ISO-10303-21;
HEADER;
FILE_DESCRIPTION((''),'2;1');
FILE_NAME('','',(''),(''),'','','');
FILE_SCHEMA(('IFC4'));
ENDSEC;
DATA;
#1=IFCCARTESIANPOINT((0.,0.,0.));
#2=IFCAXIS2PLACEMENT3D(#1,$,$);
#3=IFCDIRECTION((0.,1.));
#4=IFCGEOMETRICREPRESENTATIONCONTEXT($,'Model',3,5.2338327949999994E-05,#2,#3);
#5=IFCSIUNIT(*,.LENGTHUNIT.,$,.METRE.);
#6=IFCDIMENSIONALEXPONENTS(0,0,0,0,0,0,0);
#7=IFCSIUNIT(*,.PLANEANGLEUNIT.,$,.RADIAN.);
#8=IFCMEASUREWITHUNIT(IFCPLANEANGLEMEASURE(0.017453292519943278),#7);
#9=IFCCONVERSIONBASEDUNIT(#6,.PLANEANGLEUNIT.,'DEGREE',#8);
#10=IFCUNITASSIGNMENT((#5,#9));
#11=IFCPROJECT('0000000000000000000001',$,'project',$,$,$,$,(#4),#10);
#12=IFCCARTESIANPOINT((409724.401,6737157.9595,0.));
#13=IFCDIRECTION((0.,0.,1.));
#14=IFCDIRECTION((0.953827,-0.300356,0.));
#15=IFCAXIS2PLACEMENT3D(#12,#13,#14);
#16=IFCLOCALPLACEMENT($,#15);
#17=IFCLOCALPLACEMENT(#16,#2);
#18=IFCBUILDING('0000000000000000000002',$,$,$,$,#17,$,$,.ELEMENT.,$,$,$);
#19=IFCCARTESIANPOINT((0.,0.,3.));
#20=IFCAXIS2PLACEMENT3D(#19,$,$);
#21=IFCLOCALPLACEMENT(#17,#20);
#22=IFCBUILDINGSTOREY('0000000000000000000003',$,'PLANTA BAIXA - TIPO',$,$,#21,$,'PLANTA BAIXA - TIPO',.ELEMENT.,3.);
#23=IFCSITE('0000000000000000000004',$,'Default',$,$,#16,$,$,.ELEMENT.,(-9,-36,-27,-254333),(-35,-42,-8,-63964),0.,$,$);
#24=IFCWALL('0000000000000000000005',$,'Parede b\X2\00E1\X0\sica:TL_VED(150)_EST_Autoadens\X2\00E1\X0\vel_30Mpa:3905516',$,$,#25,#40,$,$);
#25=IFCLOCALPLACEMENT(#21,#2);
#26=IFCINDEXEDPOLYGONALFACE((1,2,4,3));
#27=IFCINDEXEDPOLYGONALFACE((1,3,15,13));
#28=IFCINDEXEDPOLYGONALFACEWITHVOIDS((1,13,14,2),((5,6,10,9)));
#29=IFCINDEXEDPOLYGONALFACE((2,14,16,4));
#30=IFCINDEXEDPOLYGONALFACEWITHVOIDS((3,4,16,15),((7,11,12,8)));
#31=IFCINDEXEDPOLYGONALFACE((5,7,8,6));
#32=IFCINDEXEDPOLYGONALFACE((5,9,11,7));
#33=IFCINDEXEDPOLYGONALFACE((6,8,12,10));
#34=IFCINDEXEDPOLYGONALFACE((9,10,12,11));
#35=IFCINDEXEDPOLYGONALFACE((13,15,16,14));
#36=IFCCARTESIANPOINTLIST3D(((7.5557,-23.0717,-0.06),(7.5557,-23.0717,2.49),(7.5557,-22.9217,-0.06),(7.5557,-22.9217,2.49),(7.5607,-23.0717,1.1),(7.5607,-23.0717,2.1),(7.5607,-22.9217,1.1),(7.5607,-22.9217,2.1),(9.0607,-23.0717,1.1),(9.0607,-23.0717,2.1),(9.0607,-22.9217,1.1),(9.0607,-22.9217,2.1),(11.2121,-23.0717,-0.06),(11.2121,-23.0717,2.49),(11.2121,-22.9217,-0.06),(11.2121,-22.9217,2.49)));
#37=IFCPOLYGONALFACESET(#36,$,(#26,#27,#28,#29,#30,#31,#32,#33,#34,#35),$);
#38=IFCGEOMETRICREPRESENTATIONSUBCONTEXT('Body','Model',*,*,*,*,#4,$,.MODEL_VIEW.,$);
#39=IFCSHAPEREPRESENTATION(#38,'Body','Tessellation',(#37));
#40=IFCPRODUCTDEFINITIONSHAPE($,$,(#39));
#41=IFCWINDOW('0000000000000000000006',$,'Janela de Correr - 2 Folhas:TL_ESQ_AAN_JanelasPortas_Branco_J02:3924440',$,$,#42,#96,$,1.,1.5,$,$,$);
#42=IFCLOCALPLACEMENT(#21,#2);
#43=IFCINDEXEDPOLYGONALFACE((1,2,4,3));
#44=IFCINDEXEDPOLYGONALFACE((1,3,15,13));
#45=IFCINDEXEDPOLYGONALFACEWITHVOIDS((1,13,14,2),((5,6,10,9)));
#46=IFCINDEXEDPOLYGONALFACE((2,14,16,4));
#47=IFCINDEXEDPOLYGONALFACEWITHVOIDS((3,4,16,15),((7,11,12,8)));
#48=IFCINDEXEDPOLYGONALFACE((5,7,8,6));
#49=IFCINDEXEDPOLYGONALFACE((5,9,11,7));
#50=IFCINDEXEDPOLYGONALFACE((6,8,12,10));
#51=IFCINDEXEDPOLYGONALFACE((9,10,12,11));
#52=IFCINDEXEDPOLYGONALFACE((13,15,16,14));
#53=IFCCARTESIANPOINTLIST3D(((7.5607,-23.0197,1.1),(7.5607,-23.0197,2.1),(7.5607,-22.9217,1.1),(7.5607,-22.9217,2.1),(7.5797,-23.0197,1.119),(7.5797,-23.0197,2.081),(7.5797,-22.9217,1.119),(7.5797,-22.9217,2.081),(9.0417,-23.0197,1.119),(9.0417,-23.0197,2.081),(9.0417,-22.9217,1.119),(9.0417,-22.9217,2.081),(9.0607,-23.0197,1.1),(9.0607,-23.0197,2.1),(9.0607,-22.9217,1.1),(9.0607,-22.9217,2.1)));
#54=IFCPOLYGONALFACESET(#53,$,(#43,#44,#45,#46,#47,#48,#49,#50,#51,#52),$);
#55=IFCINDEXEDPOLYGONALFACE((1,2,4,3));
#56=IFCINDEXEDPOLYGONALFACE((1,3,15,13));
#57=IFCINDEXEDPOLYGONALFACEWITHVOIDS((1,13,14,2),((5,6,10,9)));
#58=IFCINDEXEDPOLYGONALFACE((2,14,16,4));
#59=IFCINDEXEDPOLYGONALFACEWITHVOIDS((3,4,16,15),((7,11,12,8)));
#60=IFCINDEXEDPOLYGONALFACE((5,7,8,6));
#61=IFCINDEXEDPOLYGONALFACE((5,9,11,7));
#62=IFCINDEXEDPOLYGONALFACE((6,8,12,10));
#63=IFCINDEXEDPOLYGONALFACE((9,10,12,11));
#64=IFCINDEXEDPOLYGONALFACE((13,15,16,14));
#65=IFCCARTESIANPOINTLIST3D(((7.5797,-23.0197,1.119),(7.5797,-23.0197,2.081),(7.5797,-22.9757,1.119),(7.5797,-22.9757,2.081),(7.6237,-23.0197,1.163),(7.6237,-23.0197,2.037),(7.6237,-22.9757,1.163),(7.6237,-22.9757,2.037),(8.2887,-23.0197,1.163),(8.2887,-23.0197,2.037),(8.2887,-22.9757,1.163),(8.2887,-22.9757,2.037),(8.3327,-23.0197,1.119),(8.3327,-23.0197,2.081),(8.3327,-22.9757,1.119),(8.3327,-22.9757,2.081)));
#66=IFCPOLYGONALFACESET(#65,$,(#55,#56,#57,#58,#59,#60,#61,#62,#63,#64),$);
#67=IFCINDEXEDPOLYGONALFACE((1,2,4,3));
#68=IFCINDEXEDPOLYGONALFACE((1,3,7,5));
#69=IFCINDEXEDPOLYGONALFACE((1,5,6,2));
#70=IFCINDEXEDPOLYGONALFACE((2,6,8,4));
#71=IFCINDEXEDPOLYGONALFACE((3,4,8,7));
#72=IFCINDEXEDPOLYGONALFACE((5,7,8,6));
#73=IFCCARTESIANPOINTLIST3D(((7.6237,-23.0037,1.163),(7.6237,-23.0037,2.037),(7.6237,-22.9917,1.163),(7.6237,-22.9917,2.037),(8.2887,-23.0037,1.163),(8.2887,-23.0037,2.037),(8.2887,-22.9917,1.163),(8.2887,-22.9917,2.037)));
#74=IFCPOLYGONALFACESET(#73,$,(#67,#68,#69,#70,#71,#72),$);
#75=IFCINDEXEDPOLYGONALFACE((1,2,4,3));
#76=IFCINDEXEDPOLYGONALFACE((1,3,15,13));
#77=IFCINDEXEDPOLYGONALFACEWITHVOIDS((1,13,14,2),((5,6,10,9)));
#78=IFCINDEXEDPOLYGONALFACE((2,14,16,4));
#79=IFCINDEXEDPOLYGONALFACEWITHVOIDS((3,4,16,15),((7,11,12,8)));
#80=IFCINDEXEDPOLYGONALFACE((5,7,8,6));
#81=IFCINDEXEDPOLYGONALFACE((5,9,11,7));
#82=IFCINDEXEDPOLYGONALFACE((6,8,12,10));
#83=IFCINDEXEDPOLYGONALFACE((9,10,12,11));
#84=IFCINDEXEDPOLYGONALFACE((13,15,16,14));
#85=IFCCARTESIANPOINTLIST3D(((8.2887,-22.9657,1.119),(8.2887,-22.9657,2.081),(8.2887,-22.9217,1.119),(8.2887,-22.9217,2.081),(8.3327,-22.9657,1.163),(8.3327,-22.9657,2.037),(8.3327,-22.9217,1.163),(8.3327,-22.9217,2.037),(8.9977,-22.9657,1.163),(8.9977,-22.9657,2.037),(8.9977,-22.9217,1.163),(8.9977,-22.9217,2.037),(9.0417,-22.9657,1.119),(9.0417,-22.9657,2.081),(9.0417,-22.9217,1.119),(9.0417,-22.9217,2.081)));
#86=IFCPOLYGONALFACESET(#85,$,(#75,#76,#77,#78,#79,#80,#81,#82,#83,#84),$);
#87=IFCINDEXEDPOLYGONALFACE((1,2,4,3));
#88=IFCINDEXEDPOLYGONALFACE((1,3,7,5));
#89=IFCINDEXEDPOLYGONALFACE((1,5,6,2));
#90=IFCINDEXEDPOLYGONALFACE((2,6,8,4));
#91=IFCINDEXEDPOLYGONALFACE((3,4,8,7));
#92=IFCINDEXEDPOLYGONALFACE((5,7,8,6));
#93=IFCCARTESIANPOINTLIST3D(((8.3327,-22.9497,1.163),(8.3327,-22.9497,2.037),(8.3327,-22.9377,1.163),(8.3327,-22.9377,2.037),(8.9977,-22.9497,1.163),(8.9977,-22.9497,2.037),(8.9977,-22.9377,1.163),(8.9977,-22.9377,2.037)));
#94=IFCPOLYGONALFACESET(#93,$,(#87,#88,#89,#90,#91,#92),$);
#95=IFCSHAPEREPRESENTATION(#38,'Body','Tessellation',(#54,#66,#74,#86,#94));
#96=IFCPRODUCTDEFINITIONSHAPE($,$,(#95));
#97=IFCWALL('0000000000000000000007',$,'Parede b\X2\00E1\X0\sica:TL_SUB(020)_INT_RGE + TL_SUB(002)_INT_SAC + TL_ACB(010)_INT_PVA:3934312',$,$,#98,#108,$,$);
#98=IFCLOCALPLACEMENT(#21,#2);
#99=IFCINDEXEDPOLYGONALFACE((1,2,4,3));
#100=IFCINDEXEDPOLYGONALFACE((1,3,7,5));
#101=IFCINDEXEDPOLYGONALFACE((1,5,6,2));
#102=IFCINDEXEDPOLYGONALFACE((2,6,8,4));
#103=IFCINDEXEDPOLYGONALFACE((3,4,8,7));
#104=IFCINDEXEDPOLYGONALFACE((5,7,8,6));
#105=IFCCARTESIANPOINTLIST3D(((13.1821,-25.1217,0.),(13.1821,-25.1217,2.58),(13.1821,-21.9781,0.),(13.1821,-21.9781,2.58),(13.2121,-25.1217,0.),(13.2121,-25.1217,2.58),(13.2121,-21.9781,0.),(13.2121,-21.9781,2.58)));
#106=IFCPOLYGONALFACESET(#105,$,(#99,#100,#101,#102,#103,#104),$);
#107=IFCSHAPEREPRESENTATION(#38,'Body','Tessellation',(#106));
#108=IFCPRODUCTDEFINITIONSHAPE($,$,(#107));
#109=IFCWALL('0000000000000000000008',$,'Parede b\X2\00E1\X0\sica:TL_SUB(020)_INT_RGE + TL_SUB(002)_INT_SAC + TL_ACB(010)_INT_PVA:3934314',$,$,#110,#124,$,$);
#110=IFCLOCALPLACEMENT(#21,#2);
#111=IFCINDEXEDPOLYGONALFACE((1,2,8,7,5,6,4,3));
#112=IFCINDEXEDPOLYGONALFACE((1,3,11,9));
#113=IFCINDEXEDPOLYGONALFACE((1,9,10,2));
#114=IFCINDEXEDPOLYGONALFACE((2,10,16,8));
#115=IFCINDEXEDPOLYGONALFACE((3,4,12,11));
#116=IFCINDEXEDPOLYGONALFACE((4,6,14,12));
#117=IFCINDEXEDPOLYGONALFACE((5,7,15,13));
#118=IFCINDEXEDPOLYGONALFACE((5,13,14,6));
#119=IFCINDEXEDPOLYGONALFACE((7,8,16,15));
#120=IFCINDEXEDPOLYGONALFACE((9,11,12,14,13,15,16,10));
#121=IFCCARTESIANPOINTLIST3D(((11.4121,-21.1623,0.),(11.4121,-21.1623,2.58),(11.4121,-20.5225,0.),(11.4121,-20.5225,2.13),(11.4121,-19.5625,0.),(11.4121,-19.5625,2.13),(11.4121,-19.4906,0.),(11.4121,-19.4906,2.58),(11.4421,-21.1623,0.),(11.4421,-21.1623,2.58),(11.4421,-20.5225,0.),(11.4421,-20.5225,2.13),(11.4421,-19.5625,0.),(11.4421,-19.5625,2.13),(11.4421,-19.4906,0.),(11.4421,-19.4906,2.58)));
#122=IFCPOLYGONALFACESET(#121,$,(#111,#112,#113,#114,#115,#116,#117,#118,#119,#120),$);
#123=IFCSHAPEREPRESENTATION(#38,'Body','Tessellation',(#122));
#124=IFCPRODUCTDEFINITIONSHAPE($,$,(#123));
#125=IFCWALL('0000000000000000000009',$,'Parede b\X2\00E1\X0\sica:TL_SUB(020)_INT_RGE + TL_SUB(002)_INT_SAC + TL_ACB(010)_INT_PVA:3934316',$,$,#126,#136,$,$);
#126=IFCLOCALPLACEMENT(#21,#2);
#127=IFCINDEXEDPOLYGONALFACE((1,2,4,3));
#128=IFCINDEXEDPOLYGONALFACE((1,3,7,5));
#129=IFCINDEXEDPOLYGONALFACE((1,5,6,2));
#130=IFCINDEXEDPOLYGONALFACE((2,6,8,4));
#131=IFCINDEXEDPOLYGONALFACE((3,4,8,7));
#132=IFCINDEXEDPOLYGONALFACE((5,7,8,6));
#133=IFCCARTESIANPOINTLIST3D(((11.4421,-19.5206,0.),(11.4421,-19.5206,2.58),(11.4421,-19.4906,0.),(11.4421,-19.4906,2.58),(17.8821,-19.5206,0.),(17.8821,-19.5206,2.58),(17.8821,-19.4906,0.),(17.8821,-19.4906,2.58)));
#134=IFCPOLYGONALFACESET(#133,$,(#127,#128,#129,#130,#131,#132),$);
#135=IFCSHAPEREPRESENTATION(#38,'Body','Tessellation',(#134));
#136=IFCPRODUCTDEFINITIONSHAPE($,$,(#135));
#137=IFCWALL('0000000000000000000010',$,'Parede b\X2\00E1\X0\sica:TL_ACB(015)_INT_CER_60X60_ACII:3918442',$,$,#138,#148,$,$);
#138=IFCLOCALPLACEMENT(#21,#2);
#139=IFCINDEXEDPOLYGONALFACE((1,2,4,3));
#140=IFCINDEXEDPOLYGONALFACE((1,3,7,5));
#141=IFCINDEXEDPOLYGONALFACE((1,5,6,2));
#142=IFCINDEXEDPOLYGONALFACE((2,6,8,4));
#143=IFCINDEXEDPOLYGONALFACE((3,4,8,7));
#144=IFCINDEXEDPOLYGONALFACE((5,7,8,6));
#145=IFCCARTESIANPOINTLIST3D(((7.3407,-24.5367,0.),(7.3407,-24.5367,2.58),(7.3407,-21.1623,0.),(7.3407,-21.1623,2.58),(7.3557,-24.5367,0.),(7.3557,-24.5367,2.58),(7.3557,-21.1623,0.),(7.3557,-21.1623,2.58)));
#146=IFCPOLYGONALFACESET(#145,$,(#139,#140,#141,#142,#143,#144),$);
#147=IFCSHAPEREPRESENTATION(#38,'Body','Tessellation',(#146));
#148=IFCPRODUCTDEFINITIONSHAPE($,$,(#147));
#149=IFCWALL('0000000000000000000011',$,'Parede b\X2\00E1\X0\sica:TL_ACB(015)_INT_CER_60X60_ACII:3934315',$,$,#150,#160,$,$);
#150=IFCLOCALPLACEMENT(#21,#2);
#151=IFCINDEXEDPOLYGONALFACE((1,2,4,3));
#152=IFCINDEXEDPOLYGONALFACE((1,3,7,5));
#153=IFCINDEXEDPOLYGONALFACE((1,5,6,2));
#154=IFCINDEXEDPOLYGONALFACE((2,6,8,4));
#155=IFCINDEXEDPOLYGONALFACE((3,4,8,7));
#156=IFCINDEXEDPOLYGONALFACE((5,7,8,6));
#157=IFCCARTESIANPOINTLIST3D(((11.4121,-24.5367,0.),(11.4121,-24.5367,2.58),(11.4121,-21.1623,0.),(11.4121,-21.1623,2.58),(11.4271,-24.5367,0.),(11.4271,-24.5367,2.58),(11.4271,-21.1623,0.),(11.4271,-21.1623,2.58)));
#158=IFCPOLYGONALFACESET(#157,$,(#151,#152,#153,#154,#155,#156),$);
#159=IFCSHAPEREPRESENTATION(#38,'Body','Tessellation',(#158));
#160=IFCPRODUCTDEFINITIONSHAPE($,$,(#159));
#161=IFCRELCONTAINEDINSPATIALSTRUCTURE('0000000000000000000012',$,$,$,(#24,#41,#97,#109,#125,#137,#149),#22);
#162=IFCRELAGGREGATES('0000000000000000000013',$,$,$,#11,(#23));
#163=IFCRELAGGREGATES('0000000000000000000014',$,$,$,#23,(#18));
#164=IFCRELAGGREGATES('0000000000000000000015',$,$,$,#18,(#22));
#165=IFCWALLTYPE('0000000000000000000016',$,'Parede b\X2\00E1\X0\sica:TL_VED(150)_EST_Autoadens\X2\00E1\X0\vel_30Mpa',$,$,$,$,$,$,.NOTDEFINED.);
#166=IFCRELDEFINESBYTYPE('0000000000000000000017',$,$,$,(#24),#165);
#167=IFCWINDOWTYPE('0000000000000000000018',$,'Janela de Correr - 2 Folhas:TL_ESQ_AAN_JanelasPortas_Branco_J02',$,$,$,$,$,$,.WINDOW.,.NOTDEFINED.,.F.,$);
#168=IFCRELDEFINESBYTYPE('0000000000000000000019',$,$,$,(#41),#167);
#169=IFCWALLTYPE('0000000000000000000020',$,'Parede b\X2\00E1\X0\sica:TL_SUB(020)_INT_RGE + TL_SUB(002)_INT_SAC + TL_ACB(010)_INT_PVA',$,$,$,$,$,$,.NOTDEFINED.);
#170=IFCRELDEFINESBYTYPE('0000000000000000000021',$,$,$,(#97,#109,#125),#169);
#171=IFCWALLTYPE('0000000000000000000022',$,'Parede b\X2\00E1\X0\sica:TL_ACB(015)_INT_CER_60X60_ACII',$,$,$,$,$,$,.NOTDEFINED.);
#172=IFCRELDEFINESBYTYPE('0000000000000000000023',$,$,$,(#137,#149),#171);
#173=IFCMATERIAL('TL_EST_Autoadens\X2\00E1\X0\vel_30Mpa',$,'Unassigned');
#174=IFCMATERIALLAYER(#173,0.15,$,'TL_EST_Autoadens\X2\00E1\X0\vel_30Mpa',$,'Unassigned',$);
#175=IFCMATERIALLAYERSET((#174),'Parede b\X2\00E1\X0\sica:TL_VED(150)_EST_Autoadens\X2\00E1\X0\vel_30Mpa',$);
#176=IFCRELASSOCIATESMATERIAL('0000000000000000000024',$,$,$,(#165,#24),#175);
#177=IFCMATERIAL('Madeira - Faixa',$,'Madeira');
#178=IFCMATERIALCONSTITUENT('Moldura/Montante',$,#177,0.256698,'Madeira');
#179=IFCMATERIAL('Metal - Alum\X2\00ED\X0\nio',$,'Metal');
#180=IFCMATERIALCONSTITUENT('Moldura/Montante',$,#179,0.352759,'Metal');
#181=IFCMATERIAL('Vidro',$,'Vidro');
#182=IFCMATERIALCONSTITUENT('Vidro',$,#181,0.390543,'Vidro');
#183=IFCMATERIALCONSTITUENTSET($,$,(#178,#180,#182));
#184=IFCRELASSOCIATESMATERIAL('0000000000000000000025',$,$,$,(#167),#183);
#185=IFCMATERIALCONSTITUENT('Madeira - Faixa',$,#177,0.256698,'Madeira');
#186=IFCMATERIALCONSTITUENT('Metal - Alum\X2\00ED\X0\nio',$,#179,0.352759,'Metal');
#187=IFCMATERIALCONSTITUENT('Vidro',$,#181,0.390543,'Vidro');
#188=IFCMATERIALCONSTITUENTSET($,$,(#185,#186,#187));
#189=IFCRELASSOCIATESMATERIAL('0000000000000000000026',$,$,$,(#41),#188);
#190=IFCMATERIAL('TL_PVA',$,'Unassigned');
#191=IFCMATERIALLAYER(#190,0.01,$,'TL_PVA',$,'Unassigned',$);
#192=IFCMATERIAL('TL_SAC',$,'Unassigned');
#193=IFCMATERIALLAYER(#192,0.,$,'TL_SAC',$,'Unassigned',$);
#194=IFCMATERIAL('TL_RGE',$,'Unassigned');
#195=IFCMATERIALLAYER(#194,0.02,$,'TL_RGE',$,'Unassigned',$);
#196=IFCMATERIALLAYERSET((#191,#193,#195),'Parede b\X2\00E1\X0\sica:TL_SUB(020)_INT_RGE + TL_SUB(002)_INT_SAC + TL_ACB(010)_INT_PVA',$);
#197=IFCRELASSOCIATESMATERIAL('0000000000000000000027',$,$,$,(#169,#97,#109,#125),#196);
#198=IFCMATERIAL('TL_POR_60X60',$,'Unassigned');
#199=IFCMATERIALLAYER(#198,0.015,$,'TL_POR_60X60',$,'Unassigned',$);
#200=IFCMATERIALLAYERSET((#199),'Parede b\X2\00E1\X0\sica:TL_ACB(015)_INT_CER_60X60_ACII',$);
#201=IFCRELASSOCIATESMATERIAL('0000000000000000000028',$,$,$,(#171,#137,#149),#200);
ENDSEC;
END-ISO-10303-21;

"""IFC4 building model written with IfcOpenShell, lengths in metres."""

from ifc_helpers import new_model, entity, si_unit, converted_unit, direction, frame, frame_2d, origin, origin_2d_with_axis, place, context, subcontext, project, spatial, polyline, rectangle, outline, extrude, source, transform, mapped, material, layer, layer_set, layer_usage, constituent, constituent_set, type_object, type_shapes, element, fill, save


model = new_model("IFC4")

# Units and contexts
model_context = context("Model", 3, precision=5.2338327949999994e-05, world=origin(), true_north=direction((0.0, 1.0)))
body_context = subcontext(model_context, "Body", "Model", "MODEL_VIEW")
ifc_project = project(units=[si_unit("LENGTHUNIT", "METRE"), converted_unit("PLANEANGLEUNIT", "DEGREE", entity("IfcPlaneAngleMeasure", 0.017453292519943278), si_unit("PLANEANGLEUNIT", "RADIAN"), dimensions=[0, 0, 0, 0, 0, 0, 0])], contexts=[model_context])

# Site, building, storey
site_placement = place(None, frame((409724.401, 6737157.9595, 0.0), z_axis=(0.0, 0.0, 1.0), x_axis=(0.953827, -0.300356, 0.0)))
site = spatial("IfcSite", under=ifc_project, at=site_placement, Name="Default", CompositionType="ELEMENT", RefLatitude=(-9, -36, -27, -254333), RefLongitude=(-35, -42, -8, -63964), RefElevation=0.0)
building_placement = place(site_placement, origin())
building = spatial("IfcBuilding", under=site, at=building_placement, CompositionType="ELEMENT")
storey_placement = place(building_placement, frame((0.0, 0.0, 3.0)))
storey = spatial("IfcBuildingStorey", under=building, at=storey_placement, Name="PLANTA BAIXA - TIPO", LongName="PLANTA BAIXA - TIPO", CompositionType="ELEMENT", Elevation=3.0)

# Shared definitions
ifc_material_1 = material(Name="TL_POR_60X60", Category="Unassigned")

# Wall, opening, window
ifc_material_2 = material(Name="TL_EST_Autoadensável_30Mpa", Category="Unassigned")
ifc_material_3 = material(Name="Madeira - Faixa", Category="Madeira")
ifc_material_4 = material(Name="Metal - Alumínio", Category="Metal")
ifc_material_5 = material(Name="Vidro", Category="Vidro")
ifc_layer_1 = layer(ifc_material_2, 0.15, Name="TL_EST_Autoadensável_30Mpa", Category="Unassigned")
ifc_layer_set_1 = layer_set([ifc_layer_1], Name="Parede básica:TL_VED(150)_EST_Autoadensável_30Mpa")
ifc_layer_usage_1 = layer_usage(ifc_layer_set_1, "AXIS2", "POSITIVE", -0.075)
wall_type_1 = type_object("IfcWallType", Name="Parede básica:TL_VED(150)_EST_Autoadensável_30Mpa", PredefinedType="NOTDEFINED", material=ifc_layer_set_1)
wall_1_placement = place(storey_placement, frame((7.5557, -22.9967, -0.06)))
wall_1 = element("IfcWall", 1, at=wall_1_placement, inside=storey, type_object=wall_type_1, material=ifc_layer_usage_1, Name="Parede básica:TL_VED(150)_EST_Autoadensável_30Mpa:3905516", context=body_context, shape_type="SweptSolid", body=[
    extrude(rectangle(XDim=3.6564, YDim=0.15, at=frame_2d((1.8282, 0.0), x_axis=(-1.0, 0.0))), origin(), (0.0, 0.0, 1.0), 2.55),
])
opening_1_placement = place(wall_1_placement, frame((1.505, 0.075, 1.16)))
opening_1 = element("IfcOpeningElement", 2, at=opening_1_placement, cuts=wall_1, PredefinedType="OPENING", context=body_context, shape_type="SweptSolid", body=[
    extrude(rectangle(XDim=1.0, YDim=1.5, at=frame_2d((0.5, 0.75), x_axis=(-1.0, 0.0))), frame((0.0, 0.0, 0.0), z_axis=(0.0, -1.0, 0.0), x_axis=(0.0, 0.0, 1.0)), (0.0, 0.0, 1.0), 0.15),
])
ifc_constituent_1 = constituent(ifc_material_3, Name="Madeira - Faixa", Category="Madeira", fraction=0.256698)
ifc_constituent_2 = constituent(ifc_material_4, Name="Metal - Alumínio", Category="Metal", fraction=0.352759)
ifc_constituent_3 = constituent(ifc_material_5, Name="Vidro", Category="Vidro", fraction=0.390543)
ifc_constituent_set_1 = constituent_set(constituents=[ifc_constituent_1, ifc_constituent_2, ifc_constituent_3])
ifc_constituent_4 = constituent(ifc_material_3, Name="Moldura/Montante", Category="Madeira", fraction=0.256698)
ifc_constituent_5 = constituent(ifc_material_4, Name="Moldura/Montante", Category="Metal", fraction=0.352759)
ifc_constituent_6 = constituent(ifc_material_5, Name="Vidro", Category="Vidro", fraction=0.390543)
ifc_constituent_set_2 = constituent_set(constituents=[ifc_constituent_4, ifc_constituent_5, ifc_constituent_6])
window_type_1 = type_object("IfcWindowType", Name="Janela de Correr - 2 Folhas:TL_ESQ_AAN_JanelasPortas_Branco_J02", ParameterTakesPrecedence=False, PartitioningType="NOTDEFINED", PredefinedType="WINDOW", material=ifc_constituent_set_2)
shared_shape_1 = source(origin(), body_context, "Body", "SweptSolid", [
    extrude(outline(polyline([(-0.75, -0.5), (0.75, -0.5), (0.75, 0.5), (-0.75, 0.5), (-0.75, -0.5)]), holes=[polyline([(-0.731, -0.481), (-0.731, 0.481), (0.731, 0.481), (0.731, -0.481), (-0.731, -0.481)])]), frame((0.75, 0.0, 0.5), z_axis=(0.0, 1.0, 0.0), x_axis=(1.0, 0.0, 0.0)), (0.0, 0.0, 1.0), 0.098),
    extrude(outline(polyline([(-0.3765, -0.481), (0.3765, -0.481), (0.3765, 0.481), (-0.3765, 0.481), (-0.3765, -0.481)]), holes=[polyline([(-0.3325, -0.437), (-0.3325, 0.437), (0.3325, 0.437), (0.3325, -0.437), (-0.3325, -0.437)])]), frame((1.1045, 0.054, 0.5), z_axis=(0.0, 1.0, 0.0), x_axis=(1.0, 0.0, 0.0)), (0.0, 0.0, 1.0), 0.044),
    extrude(rectangle(XDim=0.012, YDim=0.665, at=origin_2d_with_axis()), frame((1.1045, 0.076, 0.063), z_axis=(0.0, 0.0, 1.0), x_axis=(0.0, -1.0, 0.0)), (0.0, 0.0, 1.0), 0.874),
    extrude(outline(polyline([(-0.481, -0.3765), (0.481, -0.3765), (0.481, 0.3765), (-0.481, 0.3765), (-0.481, -0.3765)]), holes=[polyline([(-0.437, -0.3325), (-0.437, 0.3325), (0.437, 0.3325), (0.437, -0.3325), (-0.437, -0.3325)])]), frame((0.3955, 0.0, 0.5), z_axis=(0.0, 1.0, 0.0), x_axis=(0.0, 0.0, -1.0)), (0.0, 0.0, 1.0), 0.044),
    extrude(rectangle(XDim=0.012, YDim=0.665, at=origin_2d_with_axis()), frame((0.3955, 0.022, 0.063), z_axis=(0.0, 0.0, 1.0), x_axis=(0.0, -1.0, 0.0)), (0.0, 0.0, 1.0), 0.874),
])
type_shapes(window_type_1, [shared_shape_1])
window_1_placement = place(opening_1_placement, frame((0.0, 0.0, 0.0), z_axis=(0.0, 0.0, 1.0), x_axis=(-1.0, 0.0, 0.0)))
window_1 = element("IfcWindow", 3, at=window_1_placement, inside=storey, type_object=window_type_1, material=ifc_constituent_set_1, Name="Janela de Correr - 2 Folhas:TL_ESQ_AAN_JanelasPortas_Branco_J02:3924440", OverallHeight=1.0, OverallWidth=1.5, context=body_context, shape_type="MappedRepresentation", body=[
    mapped(shared_shape_1, transform((0.0, 0.0, 0.0), scale=1.0)),
])
fill(opening_1, window_1)

# Wall
ifc_material_6 = material(Name="TL_PVA", Category="Unassigned")
ifc_layer_2 = layer(ifc_material_6, 0.01, Name="TL_PVA", Category="Unassigned")
ifc_material_7 = material(Name="TL_SAC", Category="Unassigned")
ifc_layer_3 = layer(ifc_material_7, 0.0, Name="TL_SAC", Category="Unassigned")
ifc_material_8 = material(Name="TL_RGE", Category="Unassigned")
ifc_layer_4 = layer(ifc_material_8, 0.02, Name="TL_RGE", Category="Unassigned")
ifc_layer_set_2 = layer_set([ifc_layer_2, ifc_layer_3, ifc_layer_4], Name="Parede básica:TL_SUB(020)_INT_RGE + TL_SUB(002)_INT_SAC + TL_ACB(010)_INT_PVA")
ifc_layer_usage_2 = layer_usage(ifc_layer_set_2, "AXIS2", "NEGATIVE", 0.015)
wall_type_2 = type_object("IfcWallType", Name="Parede básica:TL_SUB(020)_INT_RGE + TL_SUB(002)_INT_SAC + TL_ACB(010)_INT_PVA", PredefinedType="NOTDEFINED", material=ifc_layer_set_2)
wall_2_placement = place(storey_placement, frame((13.1971, -25.1217, 0.0), z_axis=(0.0, 0.0, 1.0), x_axis=(0.0, 1.0, 0.0)))
element("IfcWall", 4, at=wall_2_placement, inside=storey, type_object=wall_type_2, material=ifc_layer_usage_2, Name="Parede básica:TL_SUB(020)_INT_RGE + TL_SUB(002)_INT_SAC + TL_ACB(010)_INT_PVA:3934312", context=body_context, shape_type="SweptSolid", body=[
    extrude(rectangle(XDim=3.1437, YDim=0.03, at=frame_2d((1.5718, 0.0), x_axis=(-1.0, 0.0))), origin(), (0.0, 0.0, 1.0), 2.58),
])

# Wall, opening
ifc_layer_usage_3 = layer_usage(ifc_layer_set_2, "AXIS2", "NEGATIVE", 0.015)
wall_3_placement = place(storey_placement, frame((11.4271, -19.4906, 0.0), z_axis=(0.0, 0.0, 1.0), x_axis=(0.0, -1.0, 0.0)))
wall_3 = element("IfcWall", 5, at=wall_3_placement, inside=storey, type_object=wall_type_2, material=ifc_layer_usage_3, Name="Parede básica:TL_SUB(020)_INT_RGE + TL_SUB(002)_INT_SAC + TL_ACB(010)_INT_PVA:3934314", context=body_context, shape_type="SweptSolid", body=[
    extrude(rectangle(XDim=1.6717, YDim=0.03, at=frame_2d((0.8359, 0.0), x_axis=(-1.0, 0.0))), origin(), (0.0, 0.0, 1.0), 2.58),
])
opening_2_placement = place(wall_3_placement, frame((-19.4906, -11.4271, 0.0)))
element("IfcOpeningElement", 6, at=opening_2_placement, cuts=wall_3, PredefinedType="OPENING", context=body_context, shape_type="SweptSolid", body=[
    extrude(rectangle(XDim=2.13, YDim=0.96, at=frame_2d((0.0, 0.0), x_axis=(0.0, 1.0))), frame((20.0425, 9.8881, 1.065), z_axis=(0.0, 1.0, 0.0), x_axis=(-1.0, 0.0, 0.0)), (0.0, 0.0, 1.0), 3.048),
])

# Walls
ifc_layer_usage_4 = layer_usage(ifc_layer_set_2, "AXIS2", "POSITIVE", -0.015)
wall_4_placement = place(storey_placement, frame((11.4421, -19.5056, 0.0)))
element("IfcWall", 7, at=wall_4_placement, inside=storey, type_object=wall_type_2, material=ifc_layer_usage_4, Name="Parede básica:TL_SUB(020)_INT_RGE + TL_SUB(002)_INT_SAC + TL_ACB(010)_INT_PVA:3934316", context=body_context, shape_type="SweptSolid", body=[
    extrude(rectangle(XDim=6.44, YDim=0.03, at=frame_2d((3.22, 0.0), x_axis=(-1.0, 0.0))), origin(), (0.0, 0.0, 1.0), 2.58),
])
ifc_layer_5 = layer(ifc_material_1, 0.015, Name="TL_POR_60X60", Category="Unassigned")
ifc_layer_set_3 = layer_set([ifc_layer_5], Name="Parede básica:TL_ACB(015)_INT_CER_60X60_ACII")
ifc_layer_usage_5 = layer_usage(ifc_layer_set_3, "AXIS2", "POSITIVE", -0.0075)
wall_type_3 = type_object("IfcWallType", Name="Parede básica:TL_ACB(015)_INT_CER_60X60_ACII", PredefinedType="NOTDEFINED", material=ifc_layer_set_3)
wall_5_placement = place(storey_placement, frame((7.3482, -21.1623, 0.0), z_axis=(0.0, 0.0, 1.0), x_axis=(0.0, -1.0, 0.0)))
element("IfcWall", 8, at=wall_5_placement, inside=storey, type_object=wall_type_3, material=ifc_layer_usage_5, Name="Parede básica:TL_ACB(015)_INT_CER_60X60_ACII:3918442", context=body_context, shape_type="SweptSolid", body=[
    extrude(rectangle(XDim=3.3744, YDim=0.015, at=frame_2d((1.6872, 0.0), x_axis=(-1.0, 0.0))), origin(), (0.0, 0.0, 1.0), 2.58),
])
ifc_layer_usage_6 = layer_usage(ifc_layer_set_3, "AXIS2", "NEGATIVE", 0.0075)
wall_6_placement = place(storey_placement, frame((11.4196, -21.1623, 0.0), z_axis=(0.0, 0.0, 1.0), x_axis=(0.0, -1.0, 0.0)))
element("IfcWall", 9, at=wall_6_placement, inside=storey, type_object=wall_type_3, material=ifc_layer_usage_6, Name="Parede básica:TL_ACB(015)_INT_CER_60X60_ACII:3934315", context=body_context, shape_type="SweptSolid", body=[
    extrude(rectangle(XDim=3.3744, YDim=0.015, at=frame_2d((1.6872, 0.0), x_axis=(-1.0, 0.0))), origin(), (0.0, 0.0, 1.0), 2.58),
])

save(model, "model.ifc")
